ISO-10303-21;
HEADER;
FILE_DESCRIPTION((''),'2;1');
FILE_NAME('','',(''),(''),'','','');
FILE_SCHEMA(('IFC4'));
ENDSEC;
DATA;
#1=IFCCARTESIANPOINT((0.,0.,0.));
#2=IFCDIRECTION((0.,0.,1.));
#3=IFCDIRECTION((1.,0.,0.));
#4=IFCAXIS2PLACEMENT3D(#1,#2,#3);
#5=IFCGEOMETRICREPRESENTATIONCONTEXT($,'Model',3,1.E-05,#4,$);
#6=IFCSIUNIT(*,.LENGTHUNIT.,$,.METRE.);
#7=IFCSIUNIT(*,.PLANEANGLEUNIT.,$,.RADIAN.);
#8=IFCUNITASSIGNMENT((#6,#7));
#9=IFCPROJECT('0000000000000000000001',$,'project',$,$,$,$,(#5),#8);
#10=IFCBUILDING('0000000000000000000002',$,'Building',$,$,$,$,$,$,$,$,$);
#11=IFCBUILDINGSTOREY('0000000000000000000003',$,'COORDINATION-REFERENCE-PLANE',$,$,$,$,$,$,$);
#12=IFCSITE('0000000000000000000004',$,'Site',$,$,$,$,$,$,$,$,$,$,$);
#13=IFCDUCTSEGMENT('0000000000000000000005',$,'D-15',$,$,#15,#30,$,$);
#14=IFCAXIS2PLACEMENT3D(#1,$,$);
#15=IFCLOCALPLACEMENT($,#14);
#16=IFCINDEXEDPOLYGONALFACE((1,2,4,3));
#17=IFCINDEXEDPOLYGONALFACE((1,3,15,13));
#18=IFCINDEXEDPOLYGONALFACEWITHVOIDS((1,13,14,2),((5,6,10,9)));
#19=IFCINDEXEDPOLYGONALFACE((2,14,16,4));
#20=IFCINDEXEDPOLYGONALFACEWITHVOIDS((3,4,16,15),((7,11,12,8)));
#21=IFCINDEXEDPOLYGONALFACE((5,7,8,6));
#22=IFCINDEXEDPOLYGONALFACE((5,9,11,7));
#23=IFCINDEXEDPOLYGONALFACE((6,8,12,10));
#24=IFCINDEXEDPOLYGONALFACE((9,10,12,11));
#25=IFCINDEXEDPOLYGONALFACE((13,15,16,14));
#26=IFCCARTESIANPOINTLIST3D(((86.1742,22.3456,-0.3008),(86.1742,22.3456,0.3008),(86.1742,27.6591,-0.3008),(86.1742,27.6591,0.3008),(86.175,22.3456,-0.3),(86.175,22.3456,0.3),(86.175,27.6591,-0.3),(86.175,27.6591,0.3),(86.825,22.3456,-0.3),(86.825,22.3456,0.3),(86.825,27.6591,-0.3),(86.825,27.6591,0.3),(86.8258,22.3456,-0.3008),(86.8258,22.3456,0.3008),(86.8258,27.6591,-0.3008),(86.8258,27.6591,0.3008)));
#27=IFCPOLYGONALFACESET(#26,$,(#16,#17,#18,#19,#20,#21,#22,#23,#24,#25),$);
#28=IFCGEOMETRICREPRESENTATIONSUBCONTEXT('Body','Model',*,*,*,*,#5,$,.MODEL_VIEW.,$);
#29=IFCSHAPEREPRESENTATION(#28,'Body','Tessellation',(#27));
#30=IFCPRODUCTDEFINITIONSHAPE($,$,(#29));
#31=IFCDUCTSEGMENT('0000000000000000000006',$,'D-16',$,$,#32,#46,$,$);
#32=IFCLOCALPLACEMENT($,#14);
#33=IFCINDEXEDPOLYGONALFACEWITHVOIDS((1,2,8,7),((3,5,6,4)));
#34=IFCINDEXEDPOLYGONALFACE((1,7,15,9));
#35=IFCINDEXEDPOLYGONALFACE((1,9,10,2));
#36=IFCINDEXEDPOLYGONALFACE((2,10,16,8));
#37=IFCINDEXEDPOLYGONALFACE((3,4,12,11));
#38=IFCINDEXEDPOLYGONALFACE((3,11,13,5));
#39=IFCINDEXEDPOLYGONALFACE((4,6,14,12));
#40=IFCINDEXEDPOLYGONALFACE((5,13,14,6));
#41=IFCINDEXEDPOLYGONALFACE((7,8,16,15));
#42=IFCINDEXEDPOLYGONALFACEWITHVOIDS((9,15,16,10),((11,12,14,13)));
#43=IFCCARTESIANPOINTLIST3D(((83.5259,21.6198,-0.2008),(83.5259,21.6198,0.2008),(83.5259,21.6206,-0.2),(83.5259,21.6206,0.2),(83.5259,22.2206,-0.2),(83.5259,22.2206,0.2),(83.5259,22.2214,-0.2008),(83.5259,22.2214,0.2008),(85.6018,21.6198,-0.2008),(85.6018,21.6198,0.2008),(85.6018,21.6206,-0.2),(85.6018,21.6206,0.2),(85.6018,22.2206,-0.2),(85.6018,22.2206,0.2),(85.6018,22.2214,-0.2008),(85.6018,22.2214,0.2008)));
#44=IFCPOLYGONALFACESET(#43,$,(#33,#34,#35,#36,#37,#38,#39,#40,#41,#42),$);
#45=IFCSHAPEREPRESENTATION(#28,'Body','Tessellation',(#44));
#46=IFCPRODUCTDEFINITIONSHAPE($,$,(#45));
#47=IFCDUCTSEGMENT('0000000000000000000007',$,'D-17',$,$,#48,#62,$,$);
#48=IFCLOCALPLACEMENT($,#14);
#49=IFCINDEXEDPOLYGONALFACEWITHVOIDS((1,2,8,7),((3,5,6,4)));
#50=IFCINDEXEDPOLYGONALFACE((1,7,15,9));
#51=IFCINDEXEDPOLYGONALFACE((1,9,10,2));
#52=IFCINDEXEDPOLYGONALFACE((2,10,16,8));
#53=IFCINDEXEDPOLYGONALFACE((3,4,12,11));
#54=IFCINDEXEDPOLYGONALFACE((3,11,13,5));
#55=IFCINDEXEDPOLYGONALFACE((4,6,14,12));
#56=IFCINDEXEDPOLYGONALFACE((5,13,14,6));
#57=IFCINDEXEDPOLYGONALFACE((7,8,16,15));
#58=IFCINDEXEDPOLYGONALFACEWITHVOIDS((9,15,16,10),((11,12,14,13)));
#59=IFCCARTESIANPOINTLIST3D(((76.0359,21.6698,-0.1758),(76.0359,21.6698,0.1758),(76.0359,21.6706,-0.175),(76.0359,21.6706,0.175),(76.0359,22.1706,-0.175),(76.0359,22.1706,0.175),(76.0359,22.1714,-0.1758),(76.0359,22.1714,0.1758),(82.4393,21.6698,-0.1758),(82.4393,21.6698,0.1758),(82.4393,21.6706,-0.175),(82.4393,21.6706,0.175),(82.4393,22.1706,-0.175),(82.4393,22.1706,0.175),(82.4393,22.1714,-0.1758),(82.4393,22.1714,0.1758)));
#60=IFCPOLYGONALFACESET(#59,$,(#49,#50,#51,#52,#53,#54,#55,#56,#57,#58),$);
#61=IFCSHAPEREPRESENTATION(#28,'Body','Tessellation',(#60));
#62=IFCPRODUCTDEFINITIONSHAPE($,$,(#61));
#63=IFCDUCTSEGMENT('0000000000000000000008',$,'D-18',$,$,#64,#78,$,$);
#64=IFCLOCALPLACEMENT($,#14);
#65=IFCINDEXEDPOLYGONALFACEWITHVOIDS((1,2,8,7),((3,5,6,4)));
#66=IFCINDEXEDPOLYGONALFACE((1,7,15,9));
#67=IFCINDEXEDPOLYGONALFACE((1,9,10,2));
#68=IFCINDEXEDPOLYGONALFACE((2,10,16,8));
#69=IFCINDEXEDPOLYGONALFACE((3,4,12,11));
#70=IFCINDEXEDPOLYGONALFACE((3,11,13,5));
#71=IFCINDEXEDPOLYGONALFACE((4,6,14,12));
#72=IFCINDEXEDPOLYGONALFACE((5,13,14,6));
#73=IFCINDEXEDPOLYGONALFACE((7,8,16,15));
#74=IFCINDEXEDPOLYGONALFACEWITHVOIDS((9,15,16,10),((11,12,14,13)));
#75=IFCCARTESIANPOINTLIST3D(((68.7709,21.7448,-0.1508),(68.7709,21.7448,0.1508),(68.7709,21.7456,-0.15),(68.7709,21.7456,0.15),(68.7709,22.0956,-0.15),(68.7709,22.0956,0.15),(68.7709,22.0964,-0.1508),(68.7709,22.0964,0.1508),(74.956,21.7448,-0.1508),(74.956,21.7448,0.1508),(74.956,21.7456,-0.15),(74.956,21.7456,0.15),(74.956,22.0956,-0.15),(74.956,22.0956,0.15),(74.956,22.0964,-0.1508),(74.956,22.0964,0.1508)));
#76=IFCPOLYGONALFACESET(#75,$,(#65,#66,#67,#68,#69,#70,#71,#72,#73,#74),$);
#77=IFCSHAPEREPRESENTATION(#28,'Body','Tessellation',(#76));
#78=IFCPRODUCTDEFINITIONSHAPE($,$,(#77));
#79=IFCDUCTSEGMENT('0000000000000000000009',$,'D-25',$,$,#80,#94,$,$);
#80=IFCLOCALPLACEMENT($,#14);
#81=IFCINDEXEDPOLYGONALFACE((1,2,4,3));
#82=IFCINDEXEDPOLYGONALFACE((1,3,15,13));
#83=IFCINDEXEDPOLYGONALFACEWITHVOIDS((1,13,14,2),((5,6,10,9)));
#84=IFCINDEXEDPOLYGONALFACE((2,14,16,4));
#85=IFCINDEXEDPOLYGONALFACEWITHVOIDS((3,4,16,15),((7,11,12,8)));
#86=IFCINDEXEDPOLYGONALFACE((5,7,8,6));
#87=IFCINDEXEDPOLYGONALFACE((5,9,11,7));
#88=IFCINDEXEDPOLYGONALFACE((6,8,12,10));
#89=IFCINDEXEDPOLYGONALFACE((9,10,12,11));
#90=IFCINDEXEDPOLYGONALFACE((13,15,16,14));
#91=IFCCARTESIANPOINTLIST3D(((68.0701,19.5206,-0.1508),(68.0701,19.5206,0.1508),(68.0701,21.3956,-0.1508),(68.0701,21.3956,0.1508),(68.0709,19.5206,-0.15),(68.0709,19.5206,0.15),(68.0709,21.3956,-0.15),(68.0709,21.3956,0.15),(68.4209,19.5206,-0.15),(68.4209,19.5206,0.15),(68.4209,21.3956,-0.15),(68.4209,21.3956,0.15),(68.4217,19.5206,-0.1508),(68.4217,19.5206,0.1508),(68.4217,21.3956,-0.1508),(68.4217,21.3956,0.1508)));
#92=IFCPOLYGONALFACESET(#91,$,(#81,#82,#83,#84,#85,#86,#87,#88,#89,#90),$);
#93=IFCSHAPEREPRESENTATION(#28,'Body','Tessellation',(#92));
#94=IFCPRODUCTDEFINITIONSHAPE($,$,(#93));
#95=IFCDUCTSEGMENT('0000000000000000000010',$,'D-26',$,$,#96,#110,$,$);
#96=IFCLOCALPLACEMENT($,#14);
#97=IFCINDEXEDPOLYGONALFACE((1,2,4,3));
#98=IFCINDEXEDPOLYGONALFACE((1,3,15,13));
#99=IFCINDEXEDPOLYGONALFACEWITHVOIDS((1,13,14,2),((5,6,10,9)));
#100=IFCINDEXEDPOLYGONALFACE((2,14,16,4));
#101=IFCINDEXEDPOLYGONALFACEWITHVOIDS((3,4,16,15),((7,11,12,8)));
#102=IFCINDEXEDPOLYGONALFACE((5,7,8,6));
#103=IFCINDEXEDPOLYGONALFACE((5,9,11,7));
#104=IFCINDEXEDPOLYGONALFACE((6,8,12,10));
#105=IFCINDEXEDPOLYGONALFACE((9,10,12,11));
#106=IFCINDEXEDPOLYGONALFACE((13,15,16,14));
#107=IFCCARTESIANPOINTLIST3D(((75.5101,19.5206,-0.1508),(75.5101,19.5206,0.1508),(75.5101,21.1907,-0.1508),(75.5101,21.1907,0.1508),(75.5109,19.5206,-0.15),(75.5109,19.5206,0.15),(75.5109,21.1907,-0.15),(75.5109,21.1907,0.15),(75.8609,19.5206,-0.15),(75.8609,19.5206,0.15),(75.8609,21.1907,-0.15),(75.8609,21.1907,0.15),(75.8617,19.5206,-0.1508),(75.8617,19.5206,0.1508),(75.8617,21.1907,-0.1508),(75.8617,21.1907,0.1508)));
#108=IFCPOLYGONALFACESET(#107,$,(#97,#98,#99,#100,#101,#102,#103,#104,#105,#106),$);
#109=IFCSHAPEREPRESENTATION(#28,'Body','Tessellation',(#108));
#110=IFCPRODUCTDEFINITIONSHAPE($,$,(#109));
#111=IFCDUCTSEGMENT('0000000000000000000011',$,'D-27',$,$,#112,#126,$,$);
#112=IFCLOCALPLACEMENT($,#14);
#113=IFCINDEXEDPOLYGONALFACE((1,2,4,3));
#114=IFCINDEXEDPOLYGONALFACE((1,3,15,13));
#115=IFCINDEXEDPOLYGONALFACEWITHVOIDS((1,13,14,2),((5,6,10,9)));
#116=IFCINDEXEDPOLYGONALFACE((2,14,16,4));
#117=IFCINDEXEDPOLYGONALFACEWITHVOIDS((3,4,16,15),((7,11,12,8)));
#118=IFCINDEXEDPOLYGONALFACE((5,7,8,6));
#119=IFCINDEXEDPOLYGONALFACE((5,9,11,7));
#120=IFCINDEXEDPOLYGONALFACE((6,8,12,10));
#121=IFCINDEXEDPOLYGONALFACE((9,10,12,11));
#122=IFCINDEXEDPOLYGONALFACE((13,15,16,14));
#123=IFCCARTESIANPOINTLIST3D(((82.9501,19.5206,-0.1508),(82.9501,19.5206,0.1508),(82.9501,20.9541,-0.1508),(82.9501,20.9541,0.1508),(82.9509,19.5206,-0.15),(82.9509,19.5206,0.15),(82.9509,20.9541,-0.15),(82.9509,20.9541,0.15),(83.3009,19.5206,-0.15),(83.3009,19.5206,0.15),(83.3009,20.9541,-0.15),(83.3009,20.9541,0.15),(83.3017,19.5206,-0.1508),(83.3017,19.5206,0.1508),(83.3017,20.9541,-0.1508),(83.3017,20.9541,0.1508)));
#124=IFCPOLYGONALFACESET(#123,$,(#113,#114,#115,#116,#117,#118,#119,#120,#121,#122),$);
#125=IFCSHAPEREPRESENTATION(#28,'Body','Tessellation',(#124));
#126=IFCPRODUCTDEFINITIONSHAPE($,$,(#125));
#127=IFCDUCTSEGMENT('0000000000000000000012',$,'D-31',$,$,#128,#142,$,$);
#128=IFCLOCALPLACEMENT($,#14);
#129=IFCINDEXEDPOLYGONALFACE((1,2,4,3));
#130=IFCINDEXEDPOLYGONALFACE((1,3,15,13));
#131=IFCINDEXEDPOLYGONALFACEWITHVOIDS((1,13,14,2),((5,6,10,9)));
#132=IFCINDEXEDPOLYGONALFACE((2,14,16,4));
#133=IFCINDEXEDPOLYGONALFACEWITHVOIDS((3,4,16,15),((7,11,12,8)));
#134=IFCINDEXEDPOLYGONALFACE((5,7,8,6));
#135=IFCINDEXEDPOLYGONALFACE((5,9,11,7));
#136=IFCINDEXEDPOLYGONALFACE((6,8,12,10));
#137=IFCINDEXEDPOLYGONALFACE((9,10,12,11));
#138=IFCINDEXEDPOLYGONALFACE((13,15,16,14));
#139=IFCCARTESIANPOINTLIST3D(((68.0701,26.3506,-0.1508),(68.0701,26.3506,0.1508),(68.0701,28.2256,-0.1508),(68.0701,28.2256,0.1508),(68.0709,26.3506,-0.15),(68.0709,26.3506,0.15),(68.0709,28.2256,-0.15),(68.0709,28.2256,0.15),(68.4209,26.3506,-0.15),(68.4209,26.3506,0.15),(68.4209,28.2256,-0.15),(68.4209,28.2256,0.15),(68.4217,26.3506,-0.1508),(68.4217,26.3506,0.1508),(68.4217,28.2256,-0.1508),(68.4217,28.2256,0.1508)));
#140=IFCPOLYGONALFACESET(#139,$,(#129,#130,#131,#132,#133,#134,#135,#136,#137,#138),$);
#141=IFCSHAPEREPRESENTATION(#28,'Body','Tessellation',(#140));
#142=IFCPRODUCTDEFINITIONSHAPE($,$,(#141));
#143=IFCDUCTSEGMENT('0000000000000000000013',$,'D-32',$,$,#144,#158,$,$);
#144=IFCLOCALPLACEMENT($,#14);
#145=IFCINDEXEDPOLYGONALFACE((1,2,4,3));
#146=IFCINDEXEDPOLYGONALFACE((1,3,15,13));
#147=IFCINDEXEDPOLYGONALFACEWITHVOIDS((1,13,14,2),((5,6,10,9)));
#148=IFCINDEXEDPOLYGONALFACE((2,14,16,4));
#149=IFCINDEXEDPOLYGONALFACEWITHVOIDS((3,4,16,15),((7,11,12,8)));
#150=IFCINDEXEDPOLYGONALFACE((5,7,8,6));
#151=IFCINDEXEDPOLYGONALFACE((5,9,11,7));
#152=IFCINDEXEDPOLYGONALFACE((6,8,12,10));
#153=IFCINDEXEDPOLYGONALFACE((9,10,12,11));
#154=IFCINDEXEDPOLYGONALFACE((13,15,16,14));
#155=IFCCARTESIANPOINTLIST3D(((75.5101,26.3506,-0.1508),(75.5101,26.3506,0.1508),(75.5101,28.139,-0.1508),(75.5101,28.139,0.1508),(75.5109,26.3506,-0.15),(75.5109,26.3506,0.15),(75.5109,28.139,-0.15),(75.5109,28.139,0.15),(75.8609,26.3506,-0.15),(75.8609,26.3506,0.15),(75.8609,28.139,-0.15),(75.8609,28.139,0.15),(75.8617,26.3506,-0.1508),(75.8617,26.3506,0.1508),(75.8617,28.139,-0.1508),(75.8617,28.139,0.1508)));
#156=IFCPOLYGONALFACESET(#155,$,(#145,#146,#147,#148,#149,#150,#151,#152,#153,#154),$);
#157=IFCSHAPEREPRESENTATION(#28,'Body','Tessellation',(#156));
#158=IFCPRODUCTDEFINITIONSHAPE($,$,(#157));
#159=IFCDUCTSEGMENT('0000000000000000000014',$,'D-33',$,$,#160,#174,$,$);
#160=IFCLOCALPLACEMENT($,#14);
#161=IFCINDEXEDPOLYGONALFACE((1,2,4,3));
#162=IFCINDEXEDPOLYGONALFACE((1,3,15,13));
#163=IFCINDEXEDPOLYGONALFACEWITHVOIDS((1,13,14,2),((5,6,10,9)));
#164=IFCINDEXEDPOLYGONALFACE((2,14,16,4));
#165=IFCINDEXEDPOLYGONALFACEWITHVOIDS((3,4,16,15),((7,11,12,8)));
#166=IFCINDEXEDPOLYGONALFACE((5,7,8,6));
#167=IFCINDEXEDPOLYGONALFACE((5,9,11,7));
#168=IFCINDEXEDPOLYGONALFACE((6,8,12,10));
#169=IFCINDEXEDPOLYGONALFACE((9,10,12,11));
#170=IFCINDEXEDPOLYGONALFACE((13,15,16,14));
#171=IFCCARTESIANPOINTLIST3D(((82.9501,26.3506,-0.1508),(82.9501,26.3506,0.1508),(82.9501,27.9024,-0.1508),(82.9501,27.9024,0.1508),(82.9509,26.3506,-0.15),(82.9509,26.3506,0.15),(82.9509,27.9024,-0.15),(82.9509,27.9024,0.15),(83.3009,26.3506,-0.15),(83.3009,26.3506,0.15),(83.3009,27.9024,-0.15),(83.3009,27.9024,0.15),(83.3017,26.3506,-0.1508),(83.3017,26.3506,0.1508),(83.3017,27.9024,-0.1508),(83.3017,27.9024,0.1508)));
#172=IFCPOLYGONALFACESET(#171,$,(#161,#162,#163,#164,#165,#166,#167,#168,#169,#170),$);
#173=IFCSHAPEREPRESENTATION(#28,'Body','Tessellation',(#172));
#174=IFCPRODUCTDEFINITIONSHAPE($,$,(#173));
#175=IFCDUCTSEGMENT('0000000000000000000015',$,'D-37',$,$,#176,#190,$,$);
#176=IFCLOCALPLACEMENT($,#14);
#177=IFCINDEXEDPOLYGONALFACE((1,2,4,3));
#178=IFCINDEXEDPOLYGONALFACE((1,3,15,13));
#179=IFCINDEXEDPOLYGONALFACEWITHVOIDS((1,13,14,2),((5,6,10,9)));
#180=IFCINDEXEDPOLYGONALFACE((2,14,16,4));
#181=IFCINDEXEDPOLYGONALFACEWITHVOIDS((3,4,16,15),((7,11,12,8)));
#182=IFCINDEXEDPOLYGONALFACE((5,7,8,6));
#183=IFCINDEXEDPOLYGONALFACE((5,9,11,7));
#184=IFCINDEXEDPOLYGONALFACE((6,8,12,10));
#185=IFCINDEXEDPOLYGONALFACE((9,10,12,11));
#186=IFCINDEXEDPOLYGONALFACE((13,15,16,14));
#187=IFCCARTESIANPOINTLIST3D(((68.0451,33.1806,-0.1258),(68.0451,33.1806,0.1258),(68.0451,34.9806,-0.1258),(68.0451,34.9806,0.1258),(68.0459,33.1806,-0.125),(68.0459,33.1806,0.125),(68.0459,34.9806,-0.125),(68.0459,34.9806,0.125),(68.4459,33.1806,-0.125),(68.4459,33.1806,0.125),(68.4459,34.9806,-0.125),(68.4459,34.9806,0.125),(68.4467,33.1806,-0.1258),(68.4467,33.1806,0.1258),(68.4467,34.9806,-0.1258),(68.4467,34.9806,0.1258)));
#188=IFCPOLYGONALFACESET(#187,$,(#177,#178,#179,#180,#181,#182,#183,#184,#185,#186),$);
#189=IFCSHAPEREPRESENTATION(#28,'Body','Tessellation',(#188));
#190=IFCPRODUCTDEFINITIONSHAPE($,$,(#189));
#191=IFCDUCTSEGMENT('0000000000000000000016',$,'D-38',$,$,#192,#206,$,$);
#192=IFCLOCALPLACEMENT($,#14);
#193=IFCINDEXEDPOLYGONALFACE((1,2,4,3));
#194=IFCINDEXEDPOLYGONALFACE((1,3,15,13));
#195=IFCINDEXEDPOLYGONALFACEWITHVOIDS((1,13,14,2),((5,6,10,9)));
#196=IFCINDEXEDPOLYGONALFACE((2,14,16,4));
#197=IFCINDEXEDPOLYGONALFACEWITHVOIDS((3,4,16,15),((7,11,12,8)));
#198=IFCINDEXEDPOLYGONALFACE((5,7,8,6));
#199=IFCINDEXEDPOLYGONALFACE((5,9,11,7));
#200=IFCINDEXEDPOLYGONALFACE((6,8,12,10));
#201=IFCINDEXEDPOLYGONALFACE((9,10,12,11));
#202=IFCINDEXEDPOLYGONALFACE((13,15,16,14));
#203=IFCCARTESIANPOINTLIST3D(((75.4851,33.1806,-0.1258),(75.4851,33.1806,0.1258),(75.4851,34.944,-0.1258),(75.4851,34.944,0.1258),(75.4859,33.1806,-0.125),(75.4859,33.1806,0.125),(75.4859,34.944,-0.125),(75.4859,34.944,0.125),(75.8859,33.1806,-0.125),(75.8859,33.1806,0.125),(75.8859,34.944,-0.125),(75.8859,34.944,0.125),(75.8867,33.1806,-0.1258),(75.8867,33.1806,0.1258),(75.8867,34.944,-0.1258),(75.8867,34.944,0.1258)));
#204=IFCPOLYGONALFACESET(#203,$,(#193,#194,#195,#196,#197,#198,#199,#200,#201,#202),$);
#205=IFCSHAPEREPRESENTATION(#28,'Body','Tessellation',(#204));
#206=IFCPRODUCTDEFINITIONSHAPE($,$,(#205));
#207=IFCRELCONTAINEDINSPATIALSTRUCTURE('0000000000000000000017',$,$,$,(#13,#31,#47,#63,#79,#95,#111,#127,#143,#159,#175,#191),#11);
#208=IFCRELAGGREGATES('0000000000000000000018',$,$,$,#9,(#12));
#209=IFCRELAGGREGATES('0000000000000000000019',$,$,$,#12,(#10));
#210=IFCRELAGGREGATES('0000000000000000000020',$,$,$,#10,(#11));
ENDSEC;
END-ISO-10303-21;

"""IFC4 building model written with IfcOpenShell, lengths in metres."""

from ifc_helpers import new_model, si_unit, frame, origin, origin_with_axes, place, context, subcontext, project, spatial, hollow_rectangle, extrude, element, save


model = new_model("IFC4")

# Units and contexts
model_context = context("Model", 3, precision=1e-05, world=origin_with_axes())
body_context = subcontext(model_context, "Body", "Model", "MODEL_VIEW")
ifc_project = project(units=[si_unit("LENGTHUNIT", "METRE"), si_unit("PLANEANGLEUNIT", "RADIAN")], contexts=[model_context])

# Site, building, storey
site = spatial("IfcSite", under=ifc_project, Name="Site")
building = spatial("IfcBuilding", under=site, Name="Building")
storey = spatial("IfcBuildingStorey", under=building, Name="COORDINATION-REFERENCE-PLANE")

# Duct segments
duct_segment_1_placement = place(None, frame((86.5, 22.3456, 0.0), z_axis=(0.0, 1.0, 0.0), x_axis=(1.0, 0.0, 0.0)))
element("IfcDuctSegment", 1, at=duct_segment_1_placement, inside=storey, Name="D-15", context=body_context, shape_type="SweptSolid", body=[
    extrude(hollow_rectangle(XDim=0.6516, YDim=0.6016, WallThickness=0.0008), origin(), (0.0, 0.0, 1.0), 5.3135),
])
duct_segment_2_placement = place(None, frame((83.5259, 21.9206, 0.0), z_axis=(1.0, 0.0, 0.0), x_axis=(0.0, 1.0, 0.0)))
element("IfcDuctSegment", 2, at=duct_segment_2_placement, inside=storey, Name="D-16", context=body_context, shape_type="SweptSolid", body=[
    extrude(hollow_rectangle(XDim=0.6016, YDim=0.4016, WallThickness=0.0008), origin(), (0.0, 0.0, 1.0), 2.0759),
])
duct_segment_3_placement = place(None, frame((76.0359, 21.9206, 0.0), z_axis=(1.0, 0.0, 0.0), x_axis=(0.0, 1.0, 0.0)))
element("IfcDuctSegment", 3, at=duct_segment_3_placement, inside=storey, Name="D-17", context=body_context, shape_type="SweptSolid", body=[
    extrude(hollow_rectangle(XDim=0.5016, YDim=0.3516, WallThickness=0.0008), origin(), (0.0, 0.0, 1.0), 6.4034),
])
duct_segment_4_placement = place(None, frame((68.7709, 21.9206, 0.0), z_axis=(1.0, 0.0, 0.0), x_axis=(0.0, 1.0, 0.0)))
element("IfcDuctSegment", 4, at=duct_segment_4_placement, inside=storey, Name="D-18", context=body_context, shape_type="SweptSolid", body=[
    extrude(hollow_rectangle(XDim=0.3516, YDim=0.3016, WallThickness=0.0008), origin(), (0.0, 0.0, 1.0), 6.1851),
])
duct_segment_5_placement = place(None, frame((68.2459, 19.5206, 0.0), z_axis=(0.0, 1.0, 0.0), x_axis=(1.0, 0.0, 0.0)))
element("IfcDuctSegment", 5, at=duct_segment_5_placement, inside=storey, Name="D-25", context=body_context, shape_type="SweptSolid", body=[
    extrude(hollow_rectangle(XDim=0.3516, YDim=0.3016, WallThickness=0.0008), origin(), (0.0, 0.0, 1.0), 1.875),
])
duct_segment_6_placement = place(None, frame((75.6859, 19.5206, 0.0), z_axis=(0.0, 1.0, 0.0), x_axis=(1.0, 0.0, 0.0)))
element("IfcDuctSegment", 6, at=duct_segment_6_placement, inside=storey, Name="D-26", context=body_context, shape_type="SweptSolid", body=[
    extrude(hollow_rectangle(XDim=0.3516, YDim=0.3016, WallThickness=0.0008), origin(), (0.0, 0.0, 1.0), 1.6701),
])
duct_segment_7_placement = place(None, frame((83.1259, 19.5206, 0.0), z_axis=(0.0, 1.0, 0.0), x_axis=(1.0, 0.0, 0.0)))
element("IfcDuctSegment", 7, at=duct_segment_7_placement, inside=storey, Name="D-27", context=body_context, shape_type="SweptSolid", body=[
    extrude(hollow_rectangle(XDim=0.3516, YDim=0.3016, WallThickness=0.0008), origin(), (0.0, 0.0, 1.0), 1.4335),
])
duct_segment_8_placement = place(None, frame((68.2459, 26.3506, 0.0), z_axis=(0.0, 1.0, 0.0), x_axis=(1.0, 0.0, 0.0)))
element("IfcDuctSegment", 8, at=duct_segment_8_placement, inside=storey, Name="D-31", context=body_context, shape_type="SweptSolid", body=[
    extrude(hollow_rectangle(XDim=0.3516, YDim=0.3016, WallThickness=0.0008), origin(), (0.0, 0.0, 1.0), 1.875),
])
duct_segment_9_placement = place(None, frame((75.6859, 26.3506, 0.0), z_axis=(0.0, 1.0, 0.0), x_axis=(1.0, 0.0, 0.0)))
element("IfcDuctSegment", 9, at=duct_segment_9_placement, inside=storey, Name="D-32", context=body_context, shape_type="SweptSolid", body=[
    extrude(hollow_rectangle(XDim=0.3516, YDim=0.3016, WallThickness=0.0008), origin(), (0.0, 0.0, 1.0), 1.7884),
])
duct_segment_10_placement = place(None, frame((83.1259, 26.3506, 0.0), z_axis=(0.0, 1.0, 0.0), x_axis=(1.0, 0.0, 0.0)))
element("IfcDuctSegment", 10, at=duct_segment_10_placement, inside=storey, Name="D-33", context=body_context, shape_type="SweptSolid", body=[
    extrude(hollow_rectangle(XDim=0.3516, YDim=0.3016, WallThickness=0.0008), origin(), (0.0, 0.0, 1.0), 1.5518),
])
duct_segment_11_placement = place(None, frame((68.2459, 33.1806, 0.0), z_axis=(0.0, 1.0, 0.0), x_axis=(1.0, 0.0, 0.0)))
element("IfcDuctSegment", 11, at=duct_segment_11_placement, inside=storey, Name="D-37", context=body_context, shape_type="SweptSolid", body=[
    extrude(hollow_rectangle(XDim=0.4016, YDim=0.2516, WallThickness=0.0008), origin(), (0.0, 0.0, 1.0), 1.8),
])
duct_segment_12_placement = place(None, frame((75.6859, 33.1806, 0.0), z_axis=(0.0, 1.0, 0.0), x_axis=(1.0, 0.0, 0.0)))
element("IfcDuctSegment", 12, at=duct_segment_12_placement, inside=storey, Name="D-38", context=body_context, shape_type="SweptSolid", body=[
    extrude(hollow_rectangle(XDim=0.4016, YDim=0.2516, WallThickness=0.0008), origin(), (0.0, 0.0, 1.0), 1.7634),
])

save(model, "model.ifc")
